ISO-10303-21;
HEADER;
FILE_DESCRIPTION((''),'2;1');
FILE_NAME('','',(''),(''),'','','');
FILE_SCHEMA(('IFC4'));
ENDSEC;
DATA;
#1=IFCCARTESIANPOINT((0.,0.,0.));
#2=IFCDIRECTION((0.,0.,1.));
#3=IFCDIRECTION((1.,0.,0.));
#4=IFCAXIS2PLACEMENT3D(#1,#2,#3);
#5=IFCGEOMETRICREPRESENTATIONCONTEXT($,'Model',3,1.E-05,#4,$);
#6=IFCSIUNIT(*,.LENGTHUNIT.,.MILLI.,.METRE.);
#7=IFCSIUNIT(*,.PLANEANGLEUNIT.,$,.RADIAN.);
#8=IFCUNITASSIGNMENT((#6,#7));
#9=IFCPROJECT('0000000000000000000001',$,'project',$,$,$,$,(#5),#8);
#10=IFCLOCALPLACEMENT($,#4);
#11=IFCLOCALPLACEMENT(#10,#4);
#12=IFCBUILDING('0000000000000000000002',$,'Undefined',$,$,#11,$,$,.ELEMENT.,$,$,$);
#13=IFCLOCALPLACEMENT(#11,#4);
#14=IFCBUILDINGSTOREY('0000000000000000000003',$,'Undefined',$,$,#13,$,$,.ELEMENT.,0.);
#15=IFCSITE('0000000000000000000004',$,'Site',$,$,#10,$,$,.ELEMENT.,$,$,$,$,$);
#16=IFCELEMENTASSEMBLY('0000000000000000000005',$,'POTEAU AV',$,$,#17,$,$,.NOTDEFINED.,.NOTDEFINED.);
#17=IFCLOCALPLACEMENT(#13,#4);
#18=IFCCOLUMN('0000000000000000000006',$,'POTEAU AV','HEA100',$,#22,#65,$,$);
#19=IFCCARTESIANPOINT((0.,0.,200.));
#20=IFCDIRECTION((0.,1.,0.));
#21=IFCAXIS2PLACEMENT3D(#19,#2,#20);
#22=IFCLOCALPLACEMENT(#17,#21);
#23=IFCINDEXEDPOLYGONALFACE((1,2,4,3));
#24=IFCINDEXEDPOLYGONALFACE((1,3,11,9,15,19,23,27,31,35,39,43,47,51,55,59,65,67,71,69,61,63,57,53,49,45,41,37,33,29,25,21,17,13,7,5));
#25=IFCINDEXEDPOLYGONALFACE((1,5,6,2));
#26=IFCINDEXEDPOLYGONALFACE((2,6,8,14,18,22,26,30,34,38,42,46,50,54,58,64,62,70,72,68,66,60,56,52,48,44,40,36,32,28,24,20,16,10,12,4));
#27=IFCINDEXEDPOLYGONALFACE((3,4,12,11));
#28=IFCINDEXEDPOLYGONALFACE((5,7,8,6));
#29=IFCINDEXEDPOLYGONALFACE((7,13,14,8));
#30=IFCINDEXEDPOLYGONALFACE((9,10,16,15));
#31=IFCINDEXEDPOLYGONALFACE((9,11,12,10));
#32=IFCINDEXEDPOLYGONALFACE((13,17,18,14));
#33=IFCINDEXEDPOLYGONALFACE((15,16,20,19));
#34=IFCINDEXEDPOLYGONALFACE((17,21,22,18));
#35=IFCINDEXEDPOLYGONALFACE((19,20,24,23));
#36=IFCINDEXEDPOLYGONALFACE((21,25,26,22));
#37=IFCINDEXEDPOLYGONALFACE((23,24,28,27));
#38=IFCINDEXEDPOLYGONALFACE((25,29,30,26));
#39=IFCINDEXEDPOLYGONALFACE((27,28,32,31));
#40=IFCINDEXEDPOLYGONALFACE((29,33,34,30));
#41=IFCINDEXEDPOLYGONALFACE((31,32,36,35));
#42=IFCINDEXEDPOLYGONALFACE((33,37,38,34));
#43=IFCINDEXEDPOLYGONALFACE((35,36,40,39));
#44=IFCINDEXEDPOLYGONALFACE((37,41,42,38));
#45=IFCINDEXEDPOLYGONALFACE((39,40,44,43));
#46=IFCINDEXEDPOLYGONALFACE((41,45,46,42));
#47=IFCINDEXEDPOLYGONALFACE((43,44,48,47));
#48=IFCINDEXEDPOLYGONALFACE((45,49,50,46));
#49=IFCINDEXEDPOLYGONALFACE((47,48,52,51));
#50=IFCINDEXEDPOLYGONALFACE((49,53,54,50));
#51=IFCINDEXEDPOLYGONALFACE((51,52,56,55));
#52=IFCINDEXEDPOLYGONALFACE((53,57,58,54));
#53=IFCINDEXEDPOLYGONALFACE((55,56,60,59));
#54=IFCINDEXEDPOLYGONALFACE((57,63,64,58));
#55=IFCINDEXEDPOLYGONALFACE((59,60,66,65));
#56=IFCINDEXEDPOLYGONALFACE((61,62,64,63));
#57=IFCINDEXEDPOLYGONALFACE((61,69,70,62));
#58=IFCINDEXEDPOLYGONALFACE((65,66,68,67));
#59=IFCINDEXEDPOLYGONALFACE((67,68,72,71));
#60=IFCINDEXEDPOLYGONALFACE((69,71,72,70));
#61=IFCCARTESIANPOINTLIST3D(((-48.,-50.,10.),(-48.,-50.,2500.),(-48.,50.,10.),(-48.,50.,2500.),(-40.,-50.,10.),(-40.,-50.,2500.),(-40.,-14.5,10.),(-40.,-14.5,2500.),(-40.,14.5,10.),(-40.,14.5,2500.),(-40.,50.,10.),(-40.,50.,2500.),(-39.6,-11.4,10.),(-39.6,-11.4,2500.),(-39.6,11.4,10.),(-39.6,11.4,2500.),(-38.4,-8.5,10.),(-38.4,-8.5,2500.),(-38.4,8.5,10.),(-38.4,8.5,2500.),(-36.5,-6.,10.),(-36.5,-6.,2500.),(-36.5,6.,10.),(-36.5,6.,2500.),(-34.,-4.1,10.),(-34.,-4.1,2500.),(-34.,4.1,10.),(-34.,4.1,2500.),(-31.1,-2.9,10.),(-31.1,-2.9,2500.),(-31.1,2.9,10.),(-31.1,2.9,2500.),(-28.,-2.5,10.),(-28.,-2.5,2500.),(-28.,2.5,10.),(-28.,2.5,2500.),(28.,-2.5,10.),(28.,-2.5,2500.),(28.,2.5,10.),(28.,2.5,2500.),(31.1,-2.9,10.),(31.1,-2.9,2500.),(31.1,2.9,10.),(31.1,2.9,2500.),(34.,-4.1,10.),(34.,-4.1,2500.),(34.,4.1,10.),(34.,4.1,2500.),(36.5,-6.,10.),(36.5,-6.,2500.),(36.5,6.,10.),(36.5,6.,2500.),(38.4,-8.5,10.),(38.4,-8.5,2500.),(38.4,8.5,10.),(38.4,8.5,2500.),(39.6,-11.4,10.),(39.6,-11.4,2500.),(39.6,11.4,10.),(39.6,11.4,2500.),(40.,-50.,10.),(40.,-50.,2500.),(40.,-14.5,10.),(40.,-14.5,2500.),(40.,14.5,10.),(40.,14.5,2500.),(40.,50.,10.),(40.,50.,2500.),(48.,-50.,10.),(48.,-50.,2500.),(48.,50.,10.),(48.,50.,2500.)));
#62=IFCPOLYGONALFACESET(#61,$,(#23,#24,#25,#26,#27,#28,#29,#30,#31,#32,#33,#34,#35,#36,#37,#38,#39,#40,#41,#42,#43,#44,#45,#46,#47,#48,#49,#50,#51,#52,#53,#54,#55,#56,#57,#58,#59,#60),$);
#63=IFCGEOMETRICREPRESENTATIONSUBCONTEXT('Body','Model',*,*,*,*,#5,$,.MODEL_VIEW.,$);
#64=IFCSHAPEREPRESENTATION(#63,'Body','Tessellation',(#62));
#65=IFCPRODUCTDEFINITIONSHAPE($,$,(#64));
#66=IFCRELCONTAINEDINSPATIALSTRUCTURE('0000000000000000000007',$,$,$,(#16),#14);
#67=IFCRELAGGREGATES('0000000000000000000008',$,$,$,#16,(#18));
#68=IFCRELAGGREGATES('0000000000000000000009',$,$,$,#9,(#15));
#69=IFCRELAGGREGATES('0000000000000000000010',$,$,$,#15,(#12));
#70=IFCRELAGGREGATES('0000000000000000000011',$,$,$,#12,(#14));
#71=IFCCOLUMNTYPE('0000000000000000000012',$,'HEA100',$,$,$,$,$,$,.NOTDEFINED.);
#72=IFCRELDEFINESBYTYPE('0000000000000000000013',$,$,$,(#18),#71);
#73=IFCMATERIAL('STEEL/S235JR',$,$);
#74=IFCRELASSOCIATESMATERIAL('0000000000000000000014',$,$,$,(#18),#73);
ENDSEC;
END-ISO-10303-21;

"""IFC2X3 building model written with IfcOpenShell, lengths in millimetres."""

from ifc_helpers import new_model, si_unit, frame, origin_with_axes, origin_2d_with_axis, place, context, subcontext, project, spatial, i_section, extrude, clip, halfspace, material, type_object, element, aggregate, save


model = new_model("IFC2X3")

# Units and contexts
model_context = context("Model", 3, precision=1e-05, world=origin_with_axes())
body_context = subcontext(model_context, "Body", "Model", "MODEL_VIEW")
ifc_project = project(units=[si_unit("LENGTHUNIT", "METRE", prefix="MILLI"), si_unit("PLANEANGLEUNIT", "RADIAN")], contexts=[model_context])

# Site, building, storey
site_placement = place(None, origin_with_axes())
site = spatial("IfcSite", under=ifc_project, at=site_placement, Name="Site", CompositionType="ELEMENT")
building_placement = place(site_placement, origin_with_axes())
building = spatial("IfcBuilding", under=site, at=building_placement, Name="Undefined", CompositionType="ELEMENT")
storey_placement = place(building_placement, origin_with_axes())
storey = spatial("IfcBuildingStorey", under=building, at=storey_placement, Name="Undefined", CompositionType="ELEMENT", Elevation=0.0)

# Shared definitions
ifc_material_1 = material(Name="STEEL/S235JR")

# Element assembly, column
assembly_1_placement = place(storey_placement, origin_with_axes())
assembly_1 = element("IfcElementAssembly", 1, at=assembly_1_placement, inside=storey, Name="POTEAU AV", AssemblyPlace="NOTDEFINED", PredefinedType="NOTDEFINED")
column_type_1 = type_object("IfcColumnType", Name="HEA100", PredefinedType="NOTDEFINED")
column_1_placement = place(assembly_1_placement, frame((0.0, 0.0, 200.0), z_axis=(0.0, 0.0, 1.0), x_axis=(0.0, 1.0, 0.0)))
column_1 = element("IfcColumn", 2, at=column_1_placement, type_object=column_type_1, material=ifc_material_1, Name="POTEAU AV", Description="HEA100", context=body_context, shape_type="Clipping", body=[
    clip(extrude(i_section(OverallWidth=100.0, OverallDepth=96.0, WebThickness=5.0, FlangeThickness=8.0, FilletRadius=12.0, at=origin_2d_with_axis()), frame((0.0, 0.0, 2500.0), z_axis=(0.0, 0.0, -1.0), x_axis=(0.0, 1.0, 0.0)), (0.0, 0.0, 1.0), 2500.0), halfspace(frame((-48.0, 0.0, 10.0), z_axis=(0.0, 0.0, 1.0), x_axis=(0.0, 1.0, 0.0)), True)),
])

aggregate(assembly_1, [column_1])

save(model, "model.ifc")
